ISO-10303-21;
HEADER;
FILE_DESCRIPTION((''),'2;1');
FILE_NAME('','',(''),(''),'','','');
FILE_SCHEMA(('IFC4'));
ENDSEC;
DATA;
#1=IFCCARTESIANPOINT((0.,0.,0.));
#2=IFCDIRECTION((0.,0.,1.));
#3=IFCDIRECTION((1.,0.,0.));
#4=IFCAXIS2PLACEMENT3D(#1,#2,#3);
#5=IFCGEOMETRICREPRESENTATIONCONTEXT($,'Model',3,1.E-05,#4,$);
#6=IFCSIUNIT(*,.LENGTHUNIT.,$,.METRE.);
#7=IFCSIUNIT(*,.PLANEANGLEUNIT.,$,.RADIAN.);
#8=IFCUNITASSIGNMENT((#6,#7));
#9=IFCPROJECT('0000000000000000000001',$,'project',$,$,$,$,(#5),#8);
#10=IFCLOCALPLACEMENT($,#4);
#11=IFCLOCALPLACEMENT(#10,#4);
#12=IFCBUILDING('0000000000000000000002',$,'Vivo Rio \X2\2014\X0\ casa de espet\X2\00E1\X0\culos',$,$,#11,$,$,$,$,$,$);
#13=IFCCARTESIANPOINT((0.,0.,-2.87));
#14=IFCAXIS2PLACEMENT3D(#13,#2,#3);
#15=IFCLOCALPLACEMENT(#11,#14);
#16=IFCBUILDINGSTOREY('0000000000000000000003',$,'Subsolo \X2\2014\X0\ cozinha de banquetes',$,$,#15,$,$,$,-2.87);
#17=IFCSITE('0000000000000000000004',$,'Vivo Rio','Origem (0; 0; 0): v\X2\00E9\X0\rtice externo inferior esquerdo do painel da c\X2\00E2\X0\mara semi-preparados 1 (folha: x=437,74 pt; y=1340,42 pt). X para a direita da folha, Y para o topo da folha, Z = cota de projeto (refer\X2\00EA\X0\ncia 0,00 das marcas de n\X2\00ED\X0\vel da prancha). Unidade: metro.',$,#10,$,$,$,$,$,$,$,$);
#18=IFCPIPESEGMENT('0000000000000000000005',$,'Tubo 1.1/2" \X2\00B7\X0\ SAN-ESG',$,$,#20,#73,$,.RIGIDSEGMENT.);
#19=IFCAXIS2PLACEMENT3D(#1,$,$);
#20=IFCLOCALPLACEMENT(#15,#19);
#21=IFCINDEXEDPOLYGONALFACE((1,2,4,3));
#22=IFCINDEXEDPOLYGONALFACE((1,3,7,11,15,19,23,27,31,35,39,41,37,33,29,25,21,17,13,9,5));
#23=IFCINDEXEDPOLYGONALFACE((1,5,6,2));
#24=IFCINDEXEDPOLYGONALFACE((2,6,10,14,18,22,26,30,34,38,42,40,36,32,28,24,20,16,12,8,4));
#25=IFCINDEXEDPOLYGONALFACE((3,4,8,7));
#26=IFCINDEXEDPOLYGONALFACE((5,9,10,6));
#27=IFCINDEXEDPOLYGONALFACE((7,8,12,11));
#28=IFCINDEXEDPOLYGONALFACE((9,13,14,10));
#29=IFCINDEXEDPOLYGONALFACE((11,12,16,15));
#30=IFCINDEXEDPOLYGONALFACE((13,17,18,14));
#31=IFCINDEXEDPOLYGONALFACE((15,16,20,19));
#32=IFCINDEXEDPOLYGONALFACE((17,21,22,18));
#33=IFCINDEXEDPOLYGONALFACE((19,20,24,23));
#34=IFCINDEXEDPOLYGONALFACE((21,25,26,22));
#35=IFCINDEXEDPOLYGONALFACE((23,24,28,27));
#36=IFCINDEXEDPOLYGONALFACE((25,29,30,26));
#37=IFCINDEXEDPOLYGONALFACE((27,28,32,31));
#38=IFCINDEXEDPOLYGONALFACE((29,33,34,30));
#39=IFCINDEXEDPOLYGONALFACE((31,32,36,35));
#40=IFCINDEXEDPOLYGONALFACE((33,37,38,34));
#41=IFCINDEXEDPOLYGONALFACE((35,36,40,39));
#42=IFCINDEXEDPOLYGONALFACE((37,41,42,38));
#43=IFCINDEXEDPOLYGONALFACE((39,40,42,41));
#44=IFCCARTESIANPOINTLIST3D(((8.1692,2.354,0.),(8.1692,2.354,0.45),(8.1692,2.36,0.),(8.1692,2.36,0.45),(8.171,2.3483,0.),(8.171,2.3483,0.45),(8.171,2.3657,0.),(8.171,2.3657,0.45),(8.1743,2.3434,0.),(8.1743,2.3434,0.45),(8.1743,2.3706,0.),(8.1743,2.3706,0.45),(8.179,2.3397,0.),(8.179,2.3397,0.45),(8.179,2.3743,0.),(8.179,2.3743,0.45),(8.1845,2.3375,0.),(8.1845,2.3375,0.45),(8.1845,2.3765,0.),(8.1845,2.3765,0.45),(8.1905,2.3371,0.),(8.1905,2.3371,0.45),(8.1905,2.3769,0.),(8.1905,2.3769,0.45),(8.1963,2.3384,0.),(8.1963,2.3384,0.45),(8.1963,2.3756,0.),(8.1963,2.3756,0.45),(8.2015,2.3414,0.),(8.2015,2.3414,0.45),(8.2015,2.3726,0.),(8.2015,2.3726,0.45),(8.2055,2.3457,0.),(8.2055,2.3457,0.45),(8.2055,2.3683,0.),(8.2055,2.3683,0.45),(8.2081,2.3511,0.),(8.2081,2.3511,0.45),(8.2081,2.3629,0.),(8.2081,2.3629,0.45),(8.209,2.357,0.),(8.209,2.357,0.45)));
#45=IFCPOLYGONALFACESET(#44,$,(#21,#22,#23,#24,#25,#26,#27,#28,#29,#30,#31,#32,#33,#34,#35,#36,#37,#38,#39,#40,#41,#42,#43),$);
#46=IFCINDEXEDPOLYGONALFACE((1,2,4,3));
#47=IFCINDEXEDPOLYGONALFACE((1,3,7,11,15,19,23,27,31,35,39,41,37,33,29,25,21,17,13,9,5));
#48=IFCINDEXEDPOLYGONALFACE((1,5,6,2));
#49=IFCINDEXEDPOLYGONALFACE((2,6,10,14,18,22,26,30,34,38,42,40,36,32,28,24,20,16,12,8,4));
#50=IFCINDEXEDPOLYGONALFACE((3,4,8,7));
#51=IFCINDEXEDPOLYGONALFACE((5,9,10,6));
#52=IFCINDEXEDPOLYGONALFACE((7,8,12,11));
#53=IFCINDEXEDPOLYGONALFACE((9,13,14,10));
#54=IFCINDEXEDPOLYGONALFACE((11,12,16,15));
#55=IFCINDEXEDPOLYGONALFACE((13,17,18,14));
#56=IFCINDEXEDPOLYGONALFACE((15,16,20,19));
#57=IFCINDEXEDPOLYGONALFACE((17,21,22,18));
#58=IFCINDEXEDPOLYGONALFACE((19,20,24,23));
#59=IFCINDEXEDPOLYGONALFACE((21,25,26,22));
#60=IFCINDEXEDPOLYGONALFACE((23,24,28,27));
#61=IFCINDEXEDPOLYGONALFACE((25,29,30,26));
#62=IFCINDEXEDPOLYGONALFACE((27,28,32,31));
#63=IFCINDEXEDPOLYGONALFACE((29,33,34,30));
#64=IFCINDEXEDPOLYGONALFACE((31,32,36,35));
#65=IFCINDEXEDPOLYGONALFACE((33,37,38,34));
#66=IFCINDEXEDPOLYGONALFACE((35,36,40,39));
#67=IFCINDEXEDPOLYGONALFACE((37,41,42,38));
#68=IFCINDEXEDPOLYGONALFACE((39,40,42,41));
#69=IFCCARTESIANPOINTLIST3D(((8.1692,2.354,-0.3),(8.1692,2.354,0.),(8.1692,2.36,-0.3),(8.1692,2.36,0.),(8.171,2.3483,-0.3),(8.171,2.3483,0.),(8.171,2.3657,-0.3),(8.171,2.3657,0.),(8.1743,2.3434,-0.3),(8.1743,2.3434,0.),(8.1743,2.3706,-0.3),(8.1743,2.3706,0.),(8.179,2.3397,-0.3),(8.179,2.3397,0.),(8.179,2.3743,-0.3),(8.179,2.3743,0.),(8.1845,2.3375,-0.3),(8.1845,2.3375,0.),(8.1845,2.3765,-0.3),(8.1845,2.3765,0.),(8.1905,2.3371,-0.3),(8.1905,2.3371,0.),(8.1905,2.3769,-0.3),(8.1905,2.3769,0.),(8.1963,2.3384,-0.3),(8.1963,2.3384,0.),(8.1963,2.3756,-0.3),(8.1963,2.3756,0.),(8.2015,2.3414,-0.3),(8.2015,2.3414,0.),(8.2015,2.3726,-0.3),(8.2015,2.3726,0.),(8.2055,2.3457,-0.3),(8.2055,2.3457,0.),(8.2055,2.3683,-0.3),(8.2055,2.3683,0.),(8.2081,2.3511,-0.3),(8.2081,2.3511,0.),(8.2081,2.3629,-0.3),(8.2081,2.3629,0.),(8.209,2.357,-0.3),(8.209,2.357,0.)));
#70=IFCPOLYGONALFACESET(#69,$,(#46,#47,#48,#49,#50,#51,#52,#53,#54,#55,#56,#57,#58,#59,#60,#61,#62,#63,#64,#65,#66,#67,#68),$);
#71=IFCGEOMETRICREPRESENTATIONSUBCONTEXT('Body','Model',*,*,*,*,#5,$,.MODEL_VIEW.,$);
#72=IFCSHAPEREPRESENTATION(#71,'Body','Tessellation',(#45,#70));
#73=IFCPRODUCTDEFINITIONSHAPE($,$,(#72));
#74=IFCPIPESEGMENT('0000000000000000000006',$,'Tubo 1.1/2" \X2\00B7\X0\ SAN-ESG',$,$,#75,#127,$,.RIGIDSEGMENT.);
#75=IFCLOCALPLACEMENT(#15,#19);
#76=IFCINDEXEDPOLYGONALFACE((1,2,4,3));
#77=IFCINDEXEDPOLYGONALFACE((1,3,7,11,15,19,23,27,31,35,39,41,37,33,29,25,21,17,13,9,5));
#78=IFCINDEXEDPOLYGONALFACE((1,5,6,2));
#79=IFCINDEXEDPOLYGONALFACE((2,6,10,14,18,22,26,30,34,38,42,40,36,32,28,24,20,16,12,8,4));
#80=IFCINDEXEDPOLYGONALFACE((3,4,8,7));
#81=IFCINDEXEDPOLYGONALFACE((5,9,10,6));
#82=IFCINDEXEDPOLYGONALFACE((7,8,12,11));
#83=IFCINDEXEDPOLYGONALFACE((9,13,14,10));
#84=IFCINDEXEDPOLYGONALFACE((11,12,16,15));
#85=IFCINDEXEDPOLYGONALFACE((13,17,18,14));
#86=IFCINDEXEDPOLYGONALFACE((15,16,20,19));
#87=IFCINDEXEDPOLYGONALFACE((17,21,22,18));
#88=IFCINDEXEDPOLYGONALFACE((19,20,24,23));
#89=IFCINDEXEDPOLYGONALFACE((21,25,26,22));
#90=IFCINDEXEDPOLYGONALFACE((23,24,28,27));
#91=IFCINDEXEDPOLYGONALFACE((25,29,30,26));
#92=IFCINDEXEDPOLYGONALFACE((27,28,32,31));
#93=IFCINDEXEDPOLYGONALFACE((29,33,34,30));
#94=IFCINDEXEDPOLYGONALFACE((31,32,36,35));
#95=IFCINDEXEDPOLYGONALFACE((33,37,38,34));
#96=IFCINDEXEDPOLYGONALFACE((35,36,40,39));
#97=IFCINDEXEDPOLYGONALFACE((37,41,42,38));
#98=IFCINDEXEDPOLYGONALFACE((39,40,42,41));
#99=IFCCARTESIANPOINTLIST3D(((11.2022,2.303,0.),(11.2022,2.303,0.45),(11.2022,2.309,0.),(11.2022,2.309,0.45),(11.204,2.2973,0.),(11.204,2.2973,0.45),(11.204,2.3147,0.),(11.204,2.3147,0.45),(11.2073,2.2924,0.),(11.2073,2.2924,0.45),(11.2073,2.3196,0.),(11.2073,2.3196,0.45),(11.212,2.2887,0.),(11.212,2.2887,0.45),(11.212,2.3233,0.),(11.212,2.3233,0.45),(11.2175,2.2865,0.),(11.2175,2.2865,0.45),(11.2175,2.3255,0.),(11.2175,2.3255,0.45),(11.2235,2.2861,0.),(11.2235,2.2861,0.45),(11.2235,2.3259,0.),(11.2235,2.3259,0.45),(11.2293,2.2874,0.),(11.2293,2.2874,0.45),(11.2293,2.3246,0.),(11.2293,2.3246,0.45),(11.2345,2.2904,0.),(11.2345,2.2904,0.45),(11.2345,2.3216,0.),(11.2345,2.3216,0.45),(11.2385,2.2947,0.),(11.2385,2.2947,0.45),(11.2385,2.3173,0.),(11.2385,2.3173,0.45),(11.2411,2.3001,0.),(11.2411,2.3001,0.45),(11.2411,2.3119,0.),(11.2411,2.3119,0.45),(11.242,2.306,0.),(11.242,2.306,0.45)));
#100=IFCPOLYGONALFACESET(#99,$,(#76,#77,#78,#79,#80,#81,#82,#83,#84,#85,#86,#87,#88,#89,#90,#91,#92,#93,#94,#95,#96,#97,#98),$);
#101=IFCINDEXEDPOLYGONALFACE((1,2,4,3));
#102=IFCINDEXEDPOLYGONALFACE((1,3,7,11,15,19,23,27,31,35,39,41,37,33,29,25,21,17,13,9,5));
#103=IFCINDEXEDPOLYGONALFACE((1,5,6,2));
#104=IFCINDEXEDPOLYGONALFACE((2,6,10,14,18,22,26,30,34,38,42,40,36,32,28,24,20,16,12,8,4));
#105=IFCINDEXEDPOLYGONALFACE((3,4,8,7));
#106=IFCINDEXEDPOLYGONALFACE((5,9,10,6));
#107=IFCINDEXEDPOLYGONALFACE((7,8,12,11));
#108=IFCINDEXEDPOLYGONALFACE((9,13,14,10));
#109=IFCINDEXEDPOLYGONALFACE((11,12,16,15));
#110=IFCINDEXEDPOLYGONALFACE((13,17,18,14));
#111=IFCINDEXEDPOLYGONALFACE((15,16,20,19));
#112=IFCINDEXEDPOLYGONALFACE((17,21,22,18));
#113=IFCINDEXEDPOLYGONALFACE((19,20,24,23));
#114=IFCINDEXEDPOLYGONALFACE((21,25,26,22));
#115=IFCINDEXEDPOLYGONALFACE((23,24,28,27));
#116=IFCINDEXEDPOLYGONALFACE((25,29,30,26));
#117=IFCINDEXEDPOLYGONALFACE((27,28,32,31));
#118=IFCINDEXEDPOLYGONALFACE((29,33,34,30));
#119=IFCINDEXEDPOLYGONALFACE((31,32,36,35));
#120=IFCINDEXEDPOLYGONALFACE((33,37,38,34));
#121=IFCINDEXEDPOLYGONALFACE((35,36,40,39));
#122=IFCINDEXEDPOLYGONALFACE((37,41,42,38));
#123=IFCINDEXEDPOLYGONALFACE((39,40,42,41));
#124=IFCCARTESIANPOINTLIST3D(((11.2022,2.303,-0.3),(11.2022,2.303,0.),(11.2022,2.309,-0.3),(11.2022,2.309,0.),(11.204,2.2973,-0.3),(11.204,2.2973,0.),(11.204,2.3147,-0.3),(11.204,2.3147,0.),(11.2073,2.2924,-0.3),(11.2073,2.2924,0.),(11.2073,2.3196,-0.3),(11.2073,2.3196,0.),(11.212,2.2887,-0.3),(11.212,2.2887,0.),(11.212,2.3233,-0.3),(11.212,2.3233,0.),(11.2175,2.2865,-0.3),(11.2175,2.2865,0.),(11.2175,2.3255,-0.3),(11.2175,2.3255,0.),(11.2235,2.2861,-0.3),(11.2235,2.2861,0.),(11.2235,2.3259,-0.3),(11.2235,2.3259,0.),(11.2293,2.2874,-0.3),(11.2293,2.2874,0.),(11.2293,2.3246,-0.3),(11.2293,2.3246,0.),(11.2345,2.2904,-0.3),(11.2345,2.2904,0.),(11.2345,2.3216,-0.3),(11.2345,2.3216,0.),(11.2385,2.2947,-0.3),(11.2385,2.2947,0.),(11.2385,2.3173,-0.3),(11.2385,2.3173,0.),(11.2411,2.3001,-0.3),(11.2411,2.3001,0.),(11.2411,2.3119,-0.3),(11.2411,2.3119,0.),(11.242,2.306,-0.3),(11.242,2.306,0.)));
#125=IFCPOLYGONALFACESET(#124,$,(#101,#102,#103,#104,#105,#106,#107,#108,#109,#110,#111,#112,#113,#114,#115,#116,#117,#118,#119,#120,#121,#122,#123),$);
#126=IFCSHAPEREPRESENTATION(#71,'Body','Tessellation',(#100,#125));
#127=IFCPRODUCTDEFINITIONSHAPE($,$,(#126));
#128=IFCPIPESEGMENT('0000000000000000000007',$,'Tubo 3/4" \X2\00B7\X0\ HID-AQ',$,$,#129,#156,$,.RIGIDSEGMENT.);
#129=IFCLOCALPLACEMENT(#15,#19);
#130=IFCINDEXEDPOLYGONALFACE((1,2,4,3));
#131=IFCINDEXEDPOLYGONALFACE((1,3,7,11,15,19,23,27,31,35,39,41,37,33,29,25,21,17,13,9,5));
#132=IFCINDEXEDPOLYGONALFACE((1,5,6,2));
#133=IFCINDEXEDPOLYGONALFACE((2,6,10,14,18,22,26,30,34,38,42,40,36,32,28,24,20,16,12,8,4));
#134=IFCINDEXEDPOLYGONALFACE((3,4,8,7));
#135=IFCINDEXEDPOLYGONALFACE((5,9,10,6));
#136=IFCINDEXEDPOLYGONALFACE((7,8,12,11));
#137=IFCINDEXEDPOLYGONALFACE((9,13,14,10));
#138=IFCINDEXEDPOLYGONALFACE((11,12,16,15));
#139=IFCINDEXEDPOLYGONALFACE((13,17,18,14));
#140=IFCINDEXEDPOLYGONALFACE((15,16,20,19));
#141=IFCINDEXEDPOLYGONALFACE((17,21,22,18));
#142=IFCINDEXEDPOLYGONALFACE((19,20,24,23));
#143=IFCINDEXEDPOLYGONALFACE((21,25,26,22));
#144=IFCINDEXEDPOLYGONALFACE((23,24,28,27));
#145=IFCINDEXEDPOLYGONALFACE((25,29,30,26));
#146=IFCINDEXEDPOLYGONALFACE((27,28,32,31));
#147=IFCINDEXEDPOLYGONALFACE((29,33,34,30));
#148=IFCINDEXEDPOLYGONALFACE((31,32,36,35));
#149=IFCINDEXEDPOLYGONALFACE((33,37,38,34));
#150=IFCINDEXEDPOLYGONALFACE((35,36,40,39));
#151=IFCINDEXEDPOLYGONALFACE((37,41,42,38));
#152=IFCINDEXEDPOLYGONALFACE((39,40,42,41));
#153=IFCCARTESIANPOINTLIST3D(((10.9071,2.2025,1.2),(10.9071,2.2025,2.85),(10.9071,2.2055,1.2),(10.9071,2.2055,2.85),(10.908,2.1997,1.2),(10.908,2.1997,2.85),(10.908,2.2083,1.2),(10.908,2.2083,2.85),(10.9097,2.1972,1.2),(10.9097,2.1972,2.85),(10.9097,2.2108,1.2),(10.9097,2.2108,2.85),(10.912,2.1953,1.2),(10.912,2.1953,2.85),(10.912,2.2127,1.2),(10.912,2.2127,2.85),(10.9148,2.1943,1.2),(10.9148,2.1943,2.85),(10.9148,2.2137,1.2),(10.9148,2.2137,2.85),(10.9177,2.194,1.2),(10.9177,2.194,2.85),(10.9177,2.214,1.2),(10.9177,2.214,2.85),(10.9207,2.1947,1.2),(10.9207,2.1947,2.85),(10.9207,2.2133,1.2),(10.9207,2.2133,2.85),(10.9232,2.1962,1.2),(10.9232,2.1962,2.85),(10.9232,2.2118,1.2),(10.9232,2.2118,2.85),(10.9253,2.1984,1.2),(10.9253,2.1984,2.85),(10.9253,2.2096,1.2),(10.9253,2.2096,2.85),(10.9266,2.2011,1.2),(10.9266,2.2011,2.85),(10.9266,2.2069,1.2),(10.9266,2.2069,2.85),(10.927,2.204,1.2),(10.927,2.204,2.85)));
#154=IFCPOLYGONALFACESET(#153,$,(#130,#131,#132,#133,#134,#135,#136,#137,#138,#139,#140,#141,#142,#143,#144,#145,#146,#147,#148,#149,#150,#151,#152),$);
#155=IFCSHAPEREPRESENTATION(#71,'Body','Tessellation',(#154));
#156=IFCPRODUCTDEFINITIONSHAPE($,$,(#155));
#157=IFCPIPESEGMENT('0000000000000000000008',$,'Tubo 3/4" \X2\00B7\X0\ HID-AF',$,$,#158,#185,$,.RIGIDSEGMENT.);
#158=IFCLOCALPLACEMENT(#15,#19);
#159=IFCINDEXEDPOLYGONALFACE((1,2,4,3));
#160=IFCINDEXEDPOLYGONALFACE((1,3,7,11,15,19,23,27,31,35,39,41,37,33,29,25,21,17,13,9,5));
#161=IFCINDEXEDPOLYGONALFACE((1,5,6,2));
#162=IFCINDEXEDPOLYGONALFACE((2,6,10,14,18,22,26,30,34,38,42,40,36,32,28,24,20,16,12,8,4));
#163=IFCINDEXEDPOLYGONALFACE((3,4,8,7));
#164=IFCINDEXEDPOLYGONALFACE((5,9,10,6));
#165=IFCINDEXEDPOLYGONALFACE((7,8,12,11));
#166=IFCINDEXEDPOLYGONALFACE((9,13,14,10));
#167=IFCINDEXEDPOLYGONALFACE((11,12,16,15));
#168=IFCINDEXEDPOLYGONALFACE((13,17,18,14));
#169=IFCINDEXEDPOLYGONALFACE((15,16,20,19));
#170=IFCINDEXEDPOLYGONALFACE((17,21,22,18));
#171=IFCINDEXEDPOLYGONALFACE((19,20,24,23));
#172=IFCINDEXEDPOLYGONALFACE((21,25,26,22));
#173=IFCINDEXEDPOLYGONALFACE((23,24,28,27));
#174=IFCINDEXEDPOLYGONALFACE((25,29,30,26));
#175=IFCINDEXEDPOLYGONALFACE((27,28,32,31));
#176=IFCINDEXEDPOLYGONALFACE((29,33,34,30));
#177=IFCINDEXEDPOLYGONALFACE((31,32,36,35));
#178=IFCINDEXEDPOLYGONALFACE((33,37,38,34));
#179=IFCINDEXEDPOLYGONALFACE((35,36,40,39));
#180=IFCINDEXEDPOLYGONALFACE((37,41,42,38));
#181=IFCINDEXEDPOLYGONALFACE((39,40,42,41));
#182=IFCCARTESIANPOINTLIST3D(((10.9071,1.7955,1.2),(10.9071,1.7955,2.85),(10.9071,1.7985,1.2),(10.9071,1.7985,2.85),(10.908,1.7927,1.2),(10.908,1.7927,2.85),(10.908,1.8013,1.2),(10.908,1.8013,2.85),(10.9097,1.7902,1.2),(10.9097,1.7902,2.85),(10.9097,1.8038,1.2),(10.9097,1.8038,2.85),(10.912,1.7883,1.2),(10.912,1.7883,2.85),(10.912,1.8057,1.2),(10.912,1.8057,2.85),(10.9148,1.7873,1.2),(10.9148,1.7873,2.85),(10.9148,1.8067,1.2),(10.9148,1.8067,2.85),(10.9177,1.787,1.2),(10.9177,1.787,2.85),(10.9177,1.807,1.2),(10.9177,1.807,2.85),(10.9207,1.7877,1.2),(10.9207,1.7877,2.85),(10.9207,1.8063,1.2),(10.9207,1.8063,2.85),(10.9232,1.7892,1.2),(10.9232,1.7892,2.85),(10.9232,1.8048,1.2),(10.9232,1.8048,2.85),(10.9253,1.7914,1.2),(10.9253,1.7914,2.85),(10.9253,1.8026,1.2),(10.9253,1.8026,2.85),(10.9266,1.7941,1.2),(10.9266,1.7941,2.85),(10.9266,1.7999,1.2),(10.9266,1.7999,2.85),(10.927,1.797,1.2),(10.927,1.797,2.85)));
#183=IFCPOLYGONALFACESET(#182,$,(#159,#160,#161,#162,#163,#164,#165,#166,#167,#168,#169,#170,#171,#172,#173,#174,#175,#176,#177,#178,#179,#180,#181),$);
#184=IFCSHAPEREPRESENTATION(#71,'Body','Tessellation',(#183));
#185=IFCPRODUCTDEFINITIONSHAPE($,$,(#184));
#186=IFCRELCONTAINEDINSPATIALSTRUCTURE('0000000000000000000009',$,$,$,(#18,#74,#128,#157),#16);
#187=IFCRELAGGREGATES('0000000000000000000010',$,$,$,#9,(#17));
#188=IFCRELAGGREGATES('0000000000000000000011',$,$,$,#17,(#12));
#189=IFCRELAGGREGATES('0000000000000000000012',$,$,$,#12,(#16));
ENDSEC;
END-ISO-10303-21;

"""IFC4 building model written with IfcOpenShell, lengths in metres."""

from ifc_helpers import new_model, si_unit, frame, origin_with_axes, origin_2d, place, context, subcontext, project, spatial, circle, extrude, element, save


model = new_model("IFC4")

# Units and contexts
model_context = context("Model", 3, precision=1e-05, world=origin_with_axes())
body_context = subcontext(model_context, "Body", "Model", "MODEL_VIEW")
ifc_project = project(units=[si_unit("LENGTHUNIT", "METRE"), si_unit("PLANEANGLEUNIT", "RADIAN")], contexts=[model_context])

# Site, building, storey
site_placement = place(None, origin_with_axes())
site = spatial("IfcSite", under=ifc_project, at=site_placement, Name="Vivo Rio", Description="Origem (0; 0; 0): vértice externo inferior esquerdo do painel da câmara semi-preparados 1 (folha: x=437,74 pt; y=1340,42 pt). X para a direita da folha, Y para o topo da folha, Z = cota de projeto (referência 0,00 das marcas de nível da prancha). Unidade: metro.")
building_placement = place(site_placement, origin_with_axes())
building = spatial("IfcBuilding", under=site, at=building_placement, Name="Vivo Rio — casa de espetáculos")
storey_placement = place(building_placement, frame((0.0, 0.0, -2.87), z_axis=(0.0, 0.0, 1.0), x_axis=(1.0, 0.0, 0.0)))
storey = spatial("IfcBuildingStorey", under=building, at=storey_placement, Name="Subsolo — cozinha de banquetes", Elevation=-2.87)

# Pipe segments
pipe_segment_1_placement = place(storey_placement, origin_with_axes())
element("IfcPipeSegment", 1, at=pipe_segment_1_placement, inside=storey, Name="Tubo 1.1/2\" · SAN-ESG", PredefinedType="RIGIDSEGMENT", context=body_context, shape_type="SweptSolid", body=[
    extrude(circle(Radius=0.02, at=origin_2d()), frame((8.189, 2.357, 0.45), z_axis=(0.0, 0.0, -1.0), x_axis=(1.0, 0.0, 0.0)), (0.0, 0.0, 1.0), 0.45),
    extrude(circle(Radius=0.02, at=origin_2d()), frame((8.189, 2.357, 0.0), z_axis=(0.0, 0.0, -1.0), x_axis=(1.0, 0.0, 0.0)), (0.0, 0.0, 1.0), 0.3),
])
pipe_segment_2_placement = place(storey_placement, origin_with_axes())
element("IfcPipeSegment", 2, at=pipe_segment_2_placement, inside=storey, Name="Tubo 1.1/2\" · SAN-ESG", PredefinedType="RIGIDSEGMENT", context=body_context, shape_type="SweptSolid", body=[
    extrude(circle(Radius=0.02, at=origin_2d()), frame((11.222, 2.306, 0.45), z_axis=(0.0, 0.0, -1.0), x_axis=(1.0, 0.0, 0.0)), (0.0, 0.0, 1.0), 0.45),
    extrude(circle(Radius=0.02, at=origin_2d()), frame((11.222, 2.306, 0.0), z_axis=(0.0, 0.0, -1.0), x_axis=(1.0, 0.0, 0.0)), (0.0, 0.0, 1.0), 0.3),
])
pipe_segment_3_placement = place(storey_placement, origin_with_axes())
element("IfcPipeSegment", 3, at=pipe_segment_3_placement, inside=storey, Name="Tubo 3/4\" · HID-AQ", PredefinedType="RIGIDSEGMENT", context=body_context, shape_type="SweptSolid", body=[
    extrude(circle(Radius=0.01, at=origin_2d()), frame((10.917, 2.204, 2.85), z_axis=(0.0, 0.0, -1.0), x_axis=(1.0, 0.0, 0.0)), (0.0, 0.0, 1.0), 1.65),
])
pipe_segment_4_placement = place(storey_placement, origin_with_axes())
element("IfcPipeSegment", 4, at=pipe_segment_4_placement, inside=storey, Name="Tubo 3/4\" · HID-AF", PredefinedType="RIGIDSEGMENT", context=body_context, shape_type="SweptSolid", body=[
    extrude(circle(Radius=0.01, at=origin_2d()), frame((10.917, 1.797, 2.85), z_axis=(0.0, 0.0, -1.0), x_axis=(1.0, 0.0, 0.0)), (0.0, 0.0, 1.0), 1.65),
])

save(model, "model.ifc")
